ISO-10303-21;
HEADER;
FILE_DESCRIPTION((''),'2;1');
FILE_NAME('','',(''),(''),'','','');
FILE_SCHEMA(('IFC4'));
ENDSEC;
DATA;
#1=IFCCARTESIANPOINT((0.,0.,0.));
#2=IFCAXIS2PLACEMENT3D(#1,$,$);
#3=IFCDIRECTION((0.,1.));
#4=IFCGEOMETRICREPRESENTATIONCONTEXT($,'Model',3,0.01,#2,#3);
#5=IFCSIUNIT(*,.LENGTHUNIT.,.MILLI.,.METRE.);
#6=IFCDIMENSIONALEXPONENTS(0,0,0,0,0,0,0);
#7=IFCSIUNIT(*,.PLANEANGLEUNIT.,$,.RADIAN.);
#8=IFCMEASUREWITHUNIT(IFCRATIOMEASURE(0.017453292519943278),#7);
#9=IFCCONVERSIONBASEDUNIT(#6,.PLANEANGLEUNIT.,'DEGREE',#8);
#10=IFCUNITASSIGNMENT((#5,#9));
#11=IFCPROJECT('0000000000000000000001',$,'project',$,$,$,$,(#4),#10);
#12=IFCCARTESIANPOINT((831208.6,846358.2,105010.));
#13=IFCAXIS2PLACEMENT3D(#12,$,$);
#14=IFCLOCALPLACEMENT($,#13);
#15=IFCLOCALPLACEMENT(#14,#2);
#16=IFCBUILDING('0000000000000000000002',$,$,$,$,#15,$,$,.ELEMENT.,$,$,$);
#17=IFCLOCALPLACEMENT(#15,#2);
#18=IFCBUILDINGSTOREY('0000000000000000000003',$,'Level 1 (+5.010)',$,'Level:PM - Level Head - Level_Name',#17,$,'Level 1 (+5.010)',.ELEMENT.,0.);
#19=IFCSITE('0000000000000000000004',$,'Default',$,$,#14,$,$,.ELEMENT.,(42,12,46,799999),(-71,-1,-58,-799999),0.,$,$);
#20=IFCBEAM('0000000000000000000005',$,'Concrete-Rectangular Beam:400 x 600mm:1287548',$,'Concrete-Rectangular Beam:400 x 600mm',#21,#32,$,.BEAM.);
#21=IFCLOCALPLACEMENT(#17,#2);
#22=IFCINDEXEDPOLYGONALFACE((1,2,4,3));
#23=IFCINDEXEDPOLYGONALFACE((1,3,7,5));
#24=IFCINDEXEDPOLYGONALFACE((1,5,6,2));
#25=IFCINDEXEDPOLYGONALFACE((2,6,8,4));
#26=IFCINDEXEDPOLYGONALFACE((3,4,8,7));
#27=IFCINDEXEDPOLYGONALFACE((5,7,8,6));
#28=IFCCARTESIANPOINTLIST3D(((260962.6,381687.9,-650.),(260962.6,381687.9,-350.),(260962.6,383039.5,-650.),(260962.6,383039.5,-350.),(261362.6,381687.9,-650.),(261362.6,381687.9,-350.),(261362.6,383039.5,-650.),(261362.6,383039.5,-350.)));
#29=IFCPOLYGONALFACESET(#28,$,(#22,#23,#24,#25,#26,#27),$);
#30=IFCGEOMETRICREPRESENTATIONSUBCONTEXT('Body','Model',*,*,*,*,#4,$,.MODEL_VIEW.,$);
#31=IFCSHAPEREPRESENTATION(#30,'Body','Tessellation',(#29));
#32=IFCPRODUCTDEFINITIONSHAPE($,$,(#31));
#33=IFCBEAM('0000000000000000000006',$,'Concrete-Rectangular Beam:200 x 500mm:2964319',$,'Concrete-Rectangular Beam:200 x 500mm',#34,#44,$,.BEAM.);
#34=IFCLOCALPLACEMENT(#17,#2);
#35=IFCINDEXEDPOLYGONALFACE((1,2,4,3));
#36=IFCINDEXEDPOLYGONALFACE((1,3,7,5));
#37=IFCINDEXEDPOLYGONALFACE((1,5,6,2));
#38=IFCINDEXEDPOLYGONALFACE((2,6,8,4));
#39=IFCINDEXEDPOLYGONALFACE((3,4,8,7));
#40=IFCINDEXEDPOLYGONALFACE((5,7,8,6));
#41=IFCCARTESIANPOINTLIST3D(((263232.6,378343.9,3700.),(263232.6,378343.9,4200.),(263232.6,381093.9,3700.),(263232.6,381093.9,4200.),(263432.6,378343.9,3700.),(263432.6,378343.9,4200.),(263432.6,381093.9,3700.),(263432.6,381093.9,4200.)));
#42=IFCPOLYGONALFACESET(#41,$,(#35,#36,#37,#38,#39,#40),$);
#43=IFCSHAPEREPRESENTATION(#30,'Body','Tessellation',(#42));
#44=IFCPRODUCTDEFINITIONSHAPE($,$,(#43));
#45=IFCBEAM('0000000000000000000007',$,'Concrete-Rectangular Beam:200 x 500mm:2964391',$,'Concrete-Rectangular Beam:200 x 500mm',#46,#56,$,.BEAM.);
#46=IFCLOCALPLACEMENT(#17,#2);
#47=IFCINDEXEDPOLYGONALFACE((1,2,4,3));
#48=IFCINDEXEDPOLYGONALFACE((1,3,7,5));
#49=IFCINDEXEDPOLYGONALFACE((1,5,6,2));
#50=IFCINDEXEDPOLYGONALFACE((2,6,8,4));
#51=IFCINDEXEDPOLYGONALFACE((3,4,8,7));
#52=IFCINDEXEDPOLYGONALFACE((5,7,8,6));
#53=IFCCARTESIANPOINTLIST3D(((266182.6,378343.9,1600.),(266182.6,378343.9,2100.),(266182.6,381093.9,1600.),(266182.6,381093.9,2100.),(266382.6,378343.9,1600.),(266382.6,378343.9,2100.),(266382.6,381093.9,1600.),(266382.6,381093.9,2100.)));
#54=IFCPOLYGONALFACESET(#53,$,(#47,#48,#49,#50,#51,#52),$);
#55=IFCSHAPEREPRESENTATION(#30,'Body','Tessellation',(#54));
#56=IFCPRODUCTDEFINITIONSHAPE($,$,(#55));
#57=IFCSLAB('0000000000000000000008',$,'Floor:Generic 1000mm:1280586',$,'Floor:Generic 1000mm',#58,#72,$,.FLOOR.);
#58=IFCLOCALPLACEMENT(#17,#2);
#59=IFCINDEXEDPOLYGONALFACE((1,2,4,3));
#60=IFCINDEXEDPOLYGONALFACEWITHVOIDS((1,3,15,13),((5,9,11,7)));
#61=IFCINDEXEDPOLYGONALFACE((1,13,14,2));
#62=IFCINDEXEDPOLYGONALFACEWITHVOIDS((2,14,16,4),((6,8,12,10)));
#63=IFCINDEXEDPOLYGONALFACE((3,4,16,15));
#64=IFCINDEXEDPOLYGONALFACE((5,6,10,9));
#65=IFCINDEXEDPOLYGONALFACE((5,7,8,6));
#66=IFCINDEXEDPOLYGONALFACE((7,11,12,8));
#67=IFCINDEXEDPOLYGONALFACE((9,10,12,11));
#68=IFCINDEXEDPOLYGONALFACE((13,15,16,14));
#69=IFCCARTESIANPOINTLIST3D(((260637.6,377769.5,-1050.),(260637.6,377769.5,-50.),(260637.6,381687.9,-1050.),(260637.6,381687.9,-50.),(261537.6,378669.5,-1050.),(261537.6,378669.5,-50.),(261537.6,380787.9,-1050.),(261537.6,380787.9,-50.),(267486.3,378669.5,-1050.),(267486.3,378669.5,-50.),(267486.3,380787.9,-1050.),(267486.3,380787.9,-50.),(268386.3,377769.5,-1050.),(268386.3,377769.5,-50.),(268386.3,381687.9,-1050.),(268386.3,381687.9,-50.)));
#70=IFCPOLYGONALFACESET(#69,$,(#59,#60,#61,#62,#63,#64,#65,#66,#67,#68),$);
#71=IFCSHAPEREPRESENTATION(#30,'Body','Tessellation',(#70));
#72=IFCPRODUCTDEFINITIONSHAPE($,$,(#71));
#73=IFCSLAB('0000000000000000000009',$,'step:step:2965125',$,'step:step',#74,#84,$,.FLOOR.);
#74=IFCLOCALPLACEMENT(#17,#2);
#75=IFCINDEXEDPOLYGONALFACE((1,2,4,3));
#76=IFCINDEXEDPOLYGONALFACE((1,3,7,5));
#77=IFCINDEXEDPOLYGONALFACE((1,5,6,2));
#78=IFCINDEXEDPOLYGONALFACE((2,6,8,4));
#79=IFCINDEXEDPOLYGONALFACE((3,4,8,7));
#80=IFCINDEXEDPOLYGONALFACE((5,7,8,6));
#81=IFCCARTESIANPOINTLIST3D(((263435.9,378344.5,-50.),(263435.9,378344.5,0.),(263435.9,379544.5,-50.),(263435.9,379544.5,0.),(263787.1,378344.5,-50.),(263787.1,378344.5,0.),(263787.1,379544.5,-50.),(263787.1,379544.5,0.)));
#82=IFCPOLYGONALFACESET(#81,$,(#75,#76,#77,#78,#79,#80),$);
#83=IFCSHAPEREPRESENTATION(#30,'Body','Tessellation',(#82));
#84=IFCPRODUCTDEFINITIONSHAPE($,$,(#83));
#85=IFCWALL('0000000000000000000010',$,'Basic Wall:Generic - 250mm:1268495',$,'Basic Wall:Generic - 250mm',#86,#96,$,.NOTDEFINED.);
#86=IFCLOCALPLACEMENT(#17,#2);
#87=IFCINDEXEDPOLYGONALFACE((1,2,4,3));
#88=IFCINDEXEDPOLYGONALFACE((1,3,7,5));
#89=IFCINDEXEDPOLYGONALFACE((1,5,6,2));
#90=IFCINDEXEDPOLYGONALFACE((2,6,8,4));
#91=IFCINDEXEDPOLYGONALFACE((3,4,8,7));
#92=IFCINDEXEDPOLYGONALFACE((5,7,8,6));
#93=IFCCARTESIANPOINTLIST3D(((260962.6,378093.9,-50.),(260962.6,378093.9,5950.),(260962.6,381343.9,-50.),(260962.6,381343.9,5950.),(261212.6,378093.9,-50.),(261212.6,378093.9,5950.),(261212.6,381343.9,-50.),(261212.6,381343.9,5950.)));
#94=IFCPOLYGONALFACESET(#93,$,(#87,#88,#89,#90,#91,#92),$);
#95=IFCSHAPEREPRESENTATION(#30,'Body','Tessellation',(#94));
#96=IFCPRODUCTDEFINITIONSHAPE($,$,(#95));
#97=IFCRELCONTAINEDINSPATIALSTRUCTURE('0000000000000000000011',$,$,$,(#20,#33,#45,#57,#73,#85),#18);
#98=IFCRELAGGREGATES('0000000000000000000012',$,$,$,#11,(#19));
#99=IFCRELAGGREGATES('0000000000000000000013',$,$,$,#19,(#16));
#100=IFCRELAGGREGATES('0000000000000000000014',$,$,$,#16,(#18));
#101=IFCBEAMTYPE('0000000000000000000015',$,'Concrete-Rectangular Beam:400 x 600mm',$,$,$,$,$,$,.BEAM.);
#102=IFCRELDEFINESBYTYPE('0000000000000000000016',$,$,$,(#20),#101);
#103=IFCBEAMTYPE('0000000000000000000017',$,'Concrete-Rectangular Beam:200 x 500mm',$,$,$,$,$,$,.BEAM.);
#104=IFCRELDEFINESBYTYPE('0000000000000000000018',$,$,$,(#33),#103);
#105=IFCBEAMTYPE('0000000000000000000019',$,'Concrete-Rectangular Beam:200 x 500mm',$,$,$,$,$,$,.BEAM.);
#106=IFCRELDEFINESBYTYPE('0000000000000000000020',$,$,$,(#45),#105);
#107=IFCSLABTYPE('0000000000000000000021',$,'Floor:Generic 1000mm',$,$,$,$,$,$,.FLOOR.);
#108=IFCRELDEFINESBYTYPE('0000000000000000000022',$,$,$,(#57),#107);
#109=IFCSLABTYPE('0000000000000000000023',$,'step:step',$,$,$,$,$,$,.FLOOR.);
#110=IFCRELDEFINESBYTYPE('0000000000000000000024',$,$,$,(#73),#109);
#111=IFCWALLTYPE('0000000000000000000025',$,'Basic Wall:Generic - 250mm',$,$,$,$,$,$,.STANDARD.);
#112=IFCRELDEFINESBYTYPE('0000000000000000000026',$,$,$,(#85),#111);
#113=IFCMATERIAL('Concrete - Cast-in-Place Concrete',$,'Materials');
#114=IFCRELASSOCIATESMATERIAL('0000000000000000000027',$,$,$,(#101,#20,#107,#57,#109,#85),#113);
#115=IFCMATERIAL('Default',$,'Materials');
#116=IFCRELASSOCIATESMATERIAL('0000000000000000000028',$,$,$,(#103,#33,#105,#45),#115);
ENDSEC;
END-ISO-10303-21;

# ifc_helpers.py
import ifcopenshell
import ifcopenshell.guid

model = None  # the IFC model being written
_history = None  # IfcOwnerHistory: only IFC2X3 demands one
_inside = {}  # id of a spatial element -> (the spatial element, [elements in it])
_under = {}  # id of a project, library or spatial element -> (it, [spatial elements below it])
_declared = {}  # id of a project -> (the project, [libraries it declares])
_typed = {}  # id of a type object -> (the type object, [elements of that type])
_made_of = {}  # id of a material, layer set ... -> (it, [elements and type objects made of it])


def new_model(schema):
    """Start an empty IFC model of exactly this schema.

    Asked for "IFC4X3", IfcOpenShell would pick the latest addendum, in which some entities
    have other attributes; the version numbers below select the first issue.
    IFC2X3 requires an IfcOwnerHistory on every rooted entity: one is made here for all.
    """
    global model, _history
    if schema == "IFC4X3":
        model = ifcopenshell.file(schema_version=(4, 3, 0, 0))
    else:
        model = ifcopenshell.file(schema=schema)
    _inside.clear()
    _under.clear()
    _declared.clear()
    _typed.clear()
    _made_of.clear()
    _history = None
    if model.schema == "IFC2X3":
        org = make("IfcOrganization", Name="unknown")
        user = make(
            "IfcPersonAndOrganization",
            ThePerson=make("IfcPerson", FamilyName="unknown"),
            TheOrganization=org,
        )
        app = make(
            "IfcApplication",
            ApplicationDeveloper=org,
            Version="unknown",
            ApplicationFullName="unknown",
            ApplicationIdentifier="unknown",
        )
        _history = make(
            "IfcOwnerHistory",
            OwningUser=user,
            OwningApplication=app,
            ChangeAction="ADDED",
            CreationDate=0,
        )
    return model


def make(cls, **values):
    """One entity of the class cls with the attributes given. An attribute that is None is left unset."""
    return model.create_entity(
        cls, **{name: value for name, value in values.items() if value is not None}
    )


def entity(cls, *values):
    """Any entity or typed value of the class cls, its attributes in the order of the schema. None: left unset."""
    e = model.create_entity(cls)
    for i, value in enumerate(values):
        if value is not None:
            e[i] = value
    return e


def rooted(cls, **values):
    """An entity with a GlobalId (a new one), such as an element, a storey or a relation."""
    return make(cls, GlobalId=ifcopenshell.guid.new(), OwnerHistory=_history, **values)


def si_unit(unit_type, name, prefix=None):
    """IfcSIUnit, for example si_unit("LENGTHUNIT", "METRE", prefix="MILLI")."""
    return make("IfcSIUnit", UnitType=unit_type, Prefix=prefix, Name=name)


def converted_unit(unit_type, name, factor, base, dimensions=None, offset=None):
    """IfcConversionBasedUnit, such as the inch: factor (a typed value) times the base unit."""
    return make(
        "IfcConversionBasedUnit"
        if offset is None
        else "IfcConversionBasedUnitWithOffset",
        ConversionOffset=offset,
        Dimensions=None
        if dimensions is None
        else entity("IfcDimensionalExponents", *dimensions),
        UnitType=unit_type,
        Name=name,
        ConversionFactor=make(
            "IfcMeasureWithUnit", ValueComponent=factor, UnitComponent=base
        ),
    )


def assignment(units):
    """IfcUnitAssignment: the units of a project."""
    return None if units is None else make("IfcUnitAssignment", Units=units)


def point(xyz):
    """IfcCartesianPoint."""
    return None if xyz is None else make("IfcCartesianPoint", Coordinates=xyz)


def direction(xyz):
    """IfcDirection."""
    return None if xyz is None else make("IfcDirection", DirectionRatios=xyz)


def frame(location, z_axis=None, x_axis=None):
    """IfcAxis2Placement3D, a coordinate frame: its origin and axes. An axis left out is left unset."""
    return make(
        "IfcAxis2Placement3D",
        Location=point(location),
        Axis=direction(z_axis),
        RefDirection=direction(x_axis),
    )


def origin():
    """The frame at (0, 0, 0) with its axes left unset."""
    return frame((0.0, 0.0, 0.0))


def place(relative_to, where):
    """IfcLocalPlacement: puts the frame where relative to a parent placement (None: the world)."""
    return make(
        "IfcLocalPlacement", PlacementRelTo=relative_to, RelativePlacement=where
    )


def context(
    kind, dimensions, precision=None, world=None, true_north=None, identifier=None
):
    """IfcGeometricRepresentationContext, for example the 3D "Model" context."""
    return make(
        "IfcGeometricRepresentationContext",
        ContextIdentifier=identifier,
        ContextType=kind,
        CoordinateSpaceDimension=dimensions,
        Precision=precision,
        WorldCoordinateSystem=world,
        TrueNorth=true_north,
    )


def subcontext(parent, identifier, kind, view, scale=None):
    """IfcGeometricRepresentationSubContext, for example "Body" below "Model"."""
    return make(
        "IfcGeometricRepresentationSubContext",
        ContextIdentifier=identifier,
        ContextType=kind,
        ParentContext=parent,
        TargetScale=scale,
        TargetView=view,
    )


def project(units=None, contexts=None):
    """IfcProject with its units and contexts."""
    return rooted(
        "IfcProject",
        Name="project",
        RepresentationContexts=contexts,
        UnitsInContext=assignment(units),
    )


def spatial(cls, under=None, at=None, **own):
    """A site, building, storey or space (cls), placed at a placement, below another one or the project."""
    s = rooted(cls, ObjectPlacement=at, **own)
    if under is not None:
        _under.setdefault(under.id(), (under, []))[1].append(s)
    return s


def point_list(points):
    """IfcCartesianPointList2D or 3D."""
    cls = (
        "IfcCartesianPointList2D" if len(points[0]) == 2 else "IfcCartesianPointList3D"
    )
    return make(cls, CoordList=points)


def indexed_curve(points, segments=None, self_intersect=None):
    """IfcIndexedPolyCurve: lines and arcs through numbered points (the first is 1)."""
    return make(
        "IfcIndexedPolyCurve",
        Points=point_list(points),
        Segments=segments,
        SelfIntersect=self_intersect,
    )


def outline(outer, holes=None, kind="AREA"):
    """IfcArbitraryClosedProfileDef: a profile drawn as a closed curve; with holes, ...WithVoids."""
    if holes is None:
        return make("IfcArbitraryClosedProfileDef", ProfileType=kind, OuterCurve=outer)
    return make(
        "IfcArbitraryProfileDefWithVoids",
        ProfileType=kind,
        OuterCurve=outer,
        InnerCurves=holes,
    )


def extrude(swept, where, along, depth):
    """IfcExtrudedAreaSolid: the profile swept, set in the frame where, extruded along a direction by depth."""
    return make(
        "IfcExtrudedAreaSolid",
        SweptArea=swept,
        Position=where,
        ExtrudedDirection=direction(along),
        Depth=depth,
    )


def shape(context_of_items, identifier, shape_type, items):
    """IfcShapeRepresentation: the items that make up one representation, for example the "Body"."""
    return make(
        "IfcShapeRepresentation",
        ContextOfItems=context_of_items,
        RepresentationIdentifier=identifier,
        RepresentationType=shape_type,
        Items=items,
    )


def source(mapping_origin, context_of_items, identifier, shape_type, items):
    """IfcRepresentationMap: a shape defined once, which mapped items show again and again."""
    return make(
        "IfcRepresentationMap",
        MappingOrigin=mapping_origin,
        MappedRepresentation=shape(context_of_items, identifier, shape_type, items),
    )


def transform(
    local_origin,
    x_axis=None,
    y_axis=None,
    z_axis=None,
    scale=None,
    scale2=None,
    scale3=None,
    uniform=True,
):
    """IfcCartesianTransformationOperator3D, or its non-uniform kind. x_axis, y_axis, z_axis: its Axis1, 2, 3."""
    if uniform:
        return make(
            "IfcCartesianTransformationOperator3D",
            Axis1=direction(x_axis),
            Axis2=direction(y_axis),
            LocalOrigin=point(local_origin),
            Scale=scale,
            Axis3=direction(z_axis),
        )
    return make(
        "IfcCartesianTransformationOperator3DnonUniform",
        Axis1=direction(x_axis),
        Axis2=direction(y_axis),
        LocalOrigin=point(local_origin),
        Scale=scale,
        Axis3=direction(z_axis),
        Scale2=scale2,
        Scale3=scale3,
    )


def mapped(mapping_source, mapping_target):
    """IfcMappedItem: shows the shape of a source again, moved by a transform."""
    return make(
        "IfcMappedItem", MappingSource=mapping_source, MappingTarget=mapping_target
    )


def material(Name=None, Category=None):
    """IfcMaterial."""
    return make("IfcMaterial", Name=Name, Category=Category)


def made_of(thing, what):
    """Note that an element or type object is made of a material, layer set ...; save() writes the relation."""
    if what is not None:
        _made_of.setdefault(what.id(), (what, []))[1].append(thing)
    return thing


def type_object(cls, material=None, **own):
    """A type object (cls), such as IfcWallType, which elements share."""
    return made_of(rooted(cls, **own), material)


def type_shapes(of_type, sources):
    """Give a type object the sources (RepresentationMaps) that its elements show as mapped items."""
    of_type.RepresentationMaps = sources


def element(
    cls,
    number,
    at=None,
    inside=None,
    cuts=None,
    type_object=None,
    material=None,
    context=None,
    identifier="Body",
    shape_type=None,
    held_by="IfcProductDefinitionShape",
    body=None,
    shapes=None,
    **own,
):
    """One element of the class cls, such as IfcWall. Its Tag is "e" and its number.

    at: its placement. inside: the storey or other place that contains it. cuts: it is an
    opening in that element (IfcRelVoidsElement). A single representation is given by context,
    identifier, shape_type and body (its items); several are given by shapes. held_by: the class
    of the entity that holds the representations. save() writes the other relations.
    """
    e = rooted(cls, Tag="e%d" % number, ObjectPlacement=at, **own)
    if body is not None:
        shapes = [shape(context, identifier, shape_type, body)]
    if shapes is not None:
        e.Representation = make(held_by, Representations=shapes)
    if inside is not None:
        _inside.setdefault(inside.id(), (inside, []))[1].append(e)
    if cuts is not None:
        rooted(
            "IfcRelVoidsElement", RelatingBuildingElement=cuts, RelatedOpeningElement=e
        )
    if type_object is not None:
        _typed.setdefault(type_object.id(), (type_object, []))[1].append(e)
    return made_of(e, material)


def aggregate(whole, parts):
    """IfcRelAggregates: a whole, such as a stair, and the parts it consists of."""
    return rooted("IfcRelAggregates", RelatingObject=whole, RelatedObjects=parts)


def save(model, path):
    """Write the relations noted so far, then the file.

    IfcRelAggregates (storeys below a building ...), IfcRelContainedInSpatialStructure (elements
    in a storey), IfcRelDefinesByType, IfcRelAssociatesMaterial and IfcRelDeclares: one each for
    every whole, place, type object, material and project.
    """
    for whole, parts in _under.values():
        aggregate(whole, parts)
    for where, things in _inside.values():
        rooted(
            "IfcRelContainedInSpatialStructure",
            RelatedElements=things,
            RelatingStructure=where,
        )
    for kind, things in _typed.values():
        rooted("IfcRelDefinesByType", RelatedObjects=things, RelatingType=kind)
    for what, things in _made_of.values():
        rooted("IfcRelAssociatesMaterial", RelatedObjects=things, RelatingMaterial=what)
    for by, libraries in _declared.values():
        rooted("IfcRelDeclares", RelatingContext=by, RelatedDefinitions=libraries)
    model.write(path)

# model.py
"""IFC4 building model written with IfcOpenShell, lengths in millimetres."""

from ifc_helpers import new_model, entity, si_unit, converted_unit, direction, frame, origin, place, context, subcontext, project, spatial, indexed_curve, outline, extrude, source, transform, mapped, material, type_object, type_shapes, element, save


model = new_model("IFC4")

# Units and contexts
model_context = context("Model", 3, precision=0.01, world=origin(), true_north=direction((0.0, 1.0)))
body_context = subcontext(model_context, "Body", "Model", "MODEL_VIEW")
ifc_project = project(units=[si_unit("LENGTHUNIT", "METRE", prefix="MILLI"), converted_unit("PLANEANGLEUNIT", "DEGREE", entity("IfcRatioMeasure", 0.017453292519943278), si_unit("PLANEANGLEUNIT", "RADIAN"), dimensions=[0, 0, 0, 0, 0, 0, 0])], contexts=[model_context])

# Site, building, storey
site_placement = place(None, frame((831208.6, 846358.2, 105010.0)))
site = spatial("IfcSite", under=ifc_project, at=site_placement, Name="Default", CompositionType="ELEMENT", RefLatitude=(42, 12, 46, 799999), RefLongitude=(-71, -1, -58, -799999), RefElevation=0.0)
building_placement = place(site_placement, origin())
building = spatial("IfcBuilding", under=site, at=building_placement, CompositionType="ELEMENT")
storey_placement = place(building_placement, origin())
storey = spatial("IfcBuildingStorey", under=building, at=storey_placement, Name="Level 1 (+5.010)", ObjectType="Level:PM - Level Head - Level_Name", LongName="Level 1 (+5.010)", CompositionType="ELEMENT", Elevation=0.0)

# Shared definitions
ifc_material_1 = material(Name="Concrete - Cast-in-Place Concrete", Category="Materials")

# Beam
beam_type_1 = type_object("IfcBeamType", Name="Concrete-Rectangular Beam:400 x 600mm", PredefinedType="BEAM", material=ifc_material_1)
shared_shape_1 = source(origin(), body_context, "Body", "SweptSolid", [
    extrude(outline(indexed_curve([(-200.0, -150.0), (200.0, -150.0), (200.0, 150.0), (-200.0, 150.0), (-200.0, -150.0)], self_intersect=False)), frame((261162.6, 383039.5, -500.0), z_axis=(0.0, -1.0, 0.0), x_axis=(-1.0, 0.0, 0.0)), (0.0, 0.0, 1.0), 1351.6),
])
type_shapes(beam_type_1, [shared_shape_1])
beam_1_placement = place(storey_placement, origin())
element("IfcBeam", 1, at=beam_1_placement, inside=storey, type_object=beam_type_1, material=ifc_material_1, Name="Concrete-Rectangular Beam:400 x 600mm:1287548", ObjectType="Concrete-Rectangular Beam:400 x 600mm", PredefinedType="BEAM", context=body_context, shape_type="MappedRepresentation", body=[
    mapped(shared_shape_1, transform((0.0, 0.0, 0.0), scale=1.0)),
])

# Beams
ifc_material_2 = material(Name="Default", Category="Materials")
beam_type_2 = type_object("IfcBeamType", Name="Concrete-Rectangular Beam:200 x 500mm", PredefinedType="BEAM", material=ifc_material_2)
shared_shape_2 = source(origin(), body_context, "Body", "SweptSolid", [
    extrude(outline(indexed_curve([(-100.0, -250.0), (100.0, -250.0), (100.0, 250.0), (-100.0, 250.0), (-100.0, -250.0)], self_intersect=False)), frame((263332.6, 378343.9, 3950.0), z_axis=(0.0, 1.0, 0.0), x_axis=(-1.0, 0.0, 0.0)), (0.0, 0.0, 1.0), 2750.0),
])
type_shapes(beam_type_2, [shared_shape_2])
beam_2_placement = place(storey_placement, origin())
element("IfcBeam", 2, at=beam_2_placement, inside=storey, type_object=beam_type_2, material=ifc_material_2, Name="Concrete-Rectangular Beam:200 x 500mm:2964319", ObjectType="Concrete-Rectangular Beam:200 x 500mm", PredefinedType="BEAM", context=body_context, shape_type="MappedRepresentation", body=[
    mapped(shared_shape_2, transform((0.0, 0.0, 0.0), scale=1.0)),
])
beam_type_3 = type_object("IfcBeamType", Name="Concrete-Rectangular Beam:200 x 500mm", PredefinedType="BEAM", material=ifc_material_2)
shared_shape_3 = source(origin(), body_context, "Body", "SweptSolid", [
    extrude(outline(indexed_curve([(-100.0, -250.0), (100.0, -250.0), (100.0, 250.0), (-100.0, 250.0), (-100.0, -250.0)], self_intersect=False)), frame((266282.6, 378343.9, 1850.0), z_axis=(0.0, 1.0, 0.0), x_axis=(-1.0, 0.0, 0.0)), (0.0, 0.0, 1.0), 2750.0),
])
type_shapes(beam_type_3, [shared_shape_3])
beam_3_placement = place(storey_placement, origin())
element("IfcBeam", 3, at=beam_3_placement, inside=storey, type_object=beam_type_3, material=ifc_material_2, Name="Concrete-Rectangular Beam:200 x 500mm:2964391", ObjectType="Concrete-Rectangular Beam:200 x 500mm", PredefinedType="BEAM", context=body_context, shape_type="MappedRepresentation", body=[
    mapped(shared_shape_3, transform((0.0, 0.0, 0.0), scale=1.0)),
])

# Slabs
slab_type_1 = type_object("IfcSlabType", Name="Floor:Generic 1000mm", PredefinedType="FLOOR", material=ifc_material_1)
slab_1_placement = place(storey_placement, origin())
element("IfcSlab", 4, at=slab_1_placement, inside=storey, type_object=slab_type_1, material=ifc_material_1, Name="Floor:Generic 1000mm:1280586", ObjectType="Floor:Generic 1000mm", PredefinedType="FLOOR", context=body_context, shape_type="SweptSolid", body=[
    extrude(outline(indexed_curve([(-1959.2, -3874.3), (1959.2, -3874.3), (1959.2, 3874.3), (-1959.2, 3874.3), (-1959.2, -3874.3)], self_intersect=False), holes=[indexed_curve([(-1059.2, -2974.3), (-1059.2, 2974.3), (1059.2, 2974.3), (1059.2, -2974.3), (-1059.2, -2974.3)], self_intersect=False)]), frame((264512.0, 379728.7, -1050.0), z_axis=(0.0, 0.0, 1.0), x_axis=(0.0, -1.0, 0.0)), (0.0, 0.0, 1.0), 1000.0),
])
slab_type_2 = type_object("IfcSlabType", Name="step:step", PredefinedType="FLOOR", material=ifc_material_1)
placement = place(building_placement, frame((0.0, 0.0, 0.0)))
slab_2_placement = place(placement, origin())
element("IfcSlab", 5, at=slab_2_placement, inside=storey, type_object=slab_type_2, Name="step:step:2965125", ObjectType="step:step", PredefinedType="FLOOR", context=body_context, shape_type="SweptSolid", body=[
    extrude(outline(indexed_curve([(-600.0, -175.6), (600.0, -175.6), (600.0, 175.6), (-600.0, 175.6), (-600.0, -175.6)], self_intersect=False)), frame((263611.5, 378944.5, -50.0), z_axis=(0.0, 0.0, 1.0), x_axis=(0.0, -1.0, 0.0)), (0.0, 0.0, 1.0), 50.0),
])

# Wall
wall_type = type_object("IfcWallType", Name="Basic Wall:Generic - 250mm", PredefinedType="STANDARD")
wall_placement = place(storey_placement, frame((261087.6, 378093.9, -50.0), z_axis=(0.0, 0.0, 1.0), x_axis=(0.0, 1.0, 0.0)))
element("IfcWall", 6, at=wall_placement, inside=storey, type_object=wall_type, material=ifc_material_1, Name="Basic Wall:Generic - 250mm:1268495", ObjectType="Basic Wall:Generic - 250mm", PredefinedType="NOTDEFINED", context=body_context, shape_type="SweptSolid", body=[
    extrude(outline(indexed_curve([(3250.0, 125.0), (0.0, 125.0), (0.0, -125.0), (3250.0, -125.0), (3250.0, 125.0)], self_intersect=False)), origin(), (0.0, 0.0, 1.0), 6000.0),
])

save(model, "model.ifc")
